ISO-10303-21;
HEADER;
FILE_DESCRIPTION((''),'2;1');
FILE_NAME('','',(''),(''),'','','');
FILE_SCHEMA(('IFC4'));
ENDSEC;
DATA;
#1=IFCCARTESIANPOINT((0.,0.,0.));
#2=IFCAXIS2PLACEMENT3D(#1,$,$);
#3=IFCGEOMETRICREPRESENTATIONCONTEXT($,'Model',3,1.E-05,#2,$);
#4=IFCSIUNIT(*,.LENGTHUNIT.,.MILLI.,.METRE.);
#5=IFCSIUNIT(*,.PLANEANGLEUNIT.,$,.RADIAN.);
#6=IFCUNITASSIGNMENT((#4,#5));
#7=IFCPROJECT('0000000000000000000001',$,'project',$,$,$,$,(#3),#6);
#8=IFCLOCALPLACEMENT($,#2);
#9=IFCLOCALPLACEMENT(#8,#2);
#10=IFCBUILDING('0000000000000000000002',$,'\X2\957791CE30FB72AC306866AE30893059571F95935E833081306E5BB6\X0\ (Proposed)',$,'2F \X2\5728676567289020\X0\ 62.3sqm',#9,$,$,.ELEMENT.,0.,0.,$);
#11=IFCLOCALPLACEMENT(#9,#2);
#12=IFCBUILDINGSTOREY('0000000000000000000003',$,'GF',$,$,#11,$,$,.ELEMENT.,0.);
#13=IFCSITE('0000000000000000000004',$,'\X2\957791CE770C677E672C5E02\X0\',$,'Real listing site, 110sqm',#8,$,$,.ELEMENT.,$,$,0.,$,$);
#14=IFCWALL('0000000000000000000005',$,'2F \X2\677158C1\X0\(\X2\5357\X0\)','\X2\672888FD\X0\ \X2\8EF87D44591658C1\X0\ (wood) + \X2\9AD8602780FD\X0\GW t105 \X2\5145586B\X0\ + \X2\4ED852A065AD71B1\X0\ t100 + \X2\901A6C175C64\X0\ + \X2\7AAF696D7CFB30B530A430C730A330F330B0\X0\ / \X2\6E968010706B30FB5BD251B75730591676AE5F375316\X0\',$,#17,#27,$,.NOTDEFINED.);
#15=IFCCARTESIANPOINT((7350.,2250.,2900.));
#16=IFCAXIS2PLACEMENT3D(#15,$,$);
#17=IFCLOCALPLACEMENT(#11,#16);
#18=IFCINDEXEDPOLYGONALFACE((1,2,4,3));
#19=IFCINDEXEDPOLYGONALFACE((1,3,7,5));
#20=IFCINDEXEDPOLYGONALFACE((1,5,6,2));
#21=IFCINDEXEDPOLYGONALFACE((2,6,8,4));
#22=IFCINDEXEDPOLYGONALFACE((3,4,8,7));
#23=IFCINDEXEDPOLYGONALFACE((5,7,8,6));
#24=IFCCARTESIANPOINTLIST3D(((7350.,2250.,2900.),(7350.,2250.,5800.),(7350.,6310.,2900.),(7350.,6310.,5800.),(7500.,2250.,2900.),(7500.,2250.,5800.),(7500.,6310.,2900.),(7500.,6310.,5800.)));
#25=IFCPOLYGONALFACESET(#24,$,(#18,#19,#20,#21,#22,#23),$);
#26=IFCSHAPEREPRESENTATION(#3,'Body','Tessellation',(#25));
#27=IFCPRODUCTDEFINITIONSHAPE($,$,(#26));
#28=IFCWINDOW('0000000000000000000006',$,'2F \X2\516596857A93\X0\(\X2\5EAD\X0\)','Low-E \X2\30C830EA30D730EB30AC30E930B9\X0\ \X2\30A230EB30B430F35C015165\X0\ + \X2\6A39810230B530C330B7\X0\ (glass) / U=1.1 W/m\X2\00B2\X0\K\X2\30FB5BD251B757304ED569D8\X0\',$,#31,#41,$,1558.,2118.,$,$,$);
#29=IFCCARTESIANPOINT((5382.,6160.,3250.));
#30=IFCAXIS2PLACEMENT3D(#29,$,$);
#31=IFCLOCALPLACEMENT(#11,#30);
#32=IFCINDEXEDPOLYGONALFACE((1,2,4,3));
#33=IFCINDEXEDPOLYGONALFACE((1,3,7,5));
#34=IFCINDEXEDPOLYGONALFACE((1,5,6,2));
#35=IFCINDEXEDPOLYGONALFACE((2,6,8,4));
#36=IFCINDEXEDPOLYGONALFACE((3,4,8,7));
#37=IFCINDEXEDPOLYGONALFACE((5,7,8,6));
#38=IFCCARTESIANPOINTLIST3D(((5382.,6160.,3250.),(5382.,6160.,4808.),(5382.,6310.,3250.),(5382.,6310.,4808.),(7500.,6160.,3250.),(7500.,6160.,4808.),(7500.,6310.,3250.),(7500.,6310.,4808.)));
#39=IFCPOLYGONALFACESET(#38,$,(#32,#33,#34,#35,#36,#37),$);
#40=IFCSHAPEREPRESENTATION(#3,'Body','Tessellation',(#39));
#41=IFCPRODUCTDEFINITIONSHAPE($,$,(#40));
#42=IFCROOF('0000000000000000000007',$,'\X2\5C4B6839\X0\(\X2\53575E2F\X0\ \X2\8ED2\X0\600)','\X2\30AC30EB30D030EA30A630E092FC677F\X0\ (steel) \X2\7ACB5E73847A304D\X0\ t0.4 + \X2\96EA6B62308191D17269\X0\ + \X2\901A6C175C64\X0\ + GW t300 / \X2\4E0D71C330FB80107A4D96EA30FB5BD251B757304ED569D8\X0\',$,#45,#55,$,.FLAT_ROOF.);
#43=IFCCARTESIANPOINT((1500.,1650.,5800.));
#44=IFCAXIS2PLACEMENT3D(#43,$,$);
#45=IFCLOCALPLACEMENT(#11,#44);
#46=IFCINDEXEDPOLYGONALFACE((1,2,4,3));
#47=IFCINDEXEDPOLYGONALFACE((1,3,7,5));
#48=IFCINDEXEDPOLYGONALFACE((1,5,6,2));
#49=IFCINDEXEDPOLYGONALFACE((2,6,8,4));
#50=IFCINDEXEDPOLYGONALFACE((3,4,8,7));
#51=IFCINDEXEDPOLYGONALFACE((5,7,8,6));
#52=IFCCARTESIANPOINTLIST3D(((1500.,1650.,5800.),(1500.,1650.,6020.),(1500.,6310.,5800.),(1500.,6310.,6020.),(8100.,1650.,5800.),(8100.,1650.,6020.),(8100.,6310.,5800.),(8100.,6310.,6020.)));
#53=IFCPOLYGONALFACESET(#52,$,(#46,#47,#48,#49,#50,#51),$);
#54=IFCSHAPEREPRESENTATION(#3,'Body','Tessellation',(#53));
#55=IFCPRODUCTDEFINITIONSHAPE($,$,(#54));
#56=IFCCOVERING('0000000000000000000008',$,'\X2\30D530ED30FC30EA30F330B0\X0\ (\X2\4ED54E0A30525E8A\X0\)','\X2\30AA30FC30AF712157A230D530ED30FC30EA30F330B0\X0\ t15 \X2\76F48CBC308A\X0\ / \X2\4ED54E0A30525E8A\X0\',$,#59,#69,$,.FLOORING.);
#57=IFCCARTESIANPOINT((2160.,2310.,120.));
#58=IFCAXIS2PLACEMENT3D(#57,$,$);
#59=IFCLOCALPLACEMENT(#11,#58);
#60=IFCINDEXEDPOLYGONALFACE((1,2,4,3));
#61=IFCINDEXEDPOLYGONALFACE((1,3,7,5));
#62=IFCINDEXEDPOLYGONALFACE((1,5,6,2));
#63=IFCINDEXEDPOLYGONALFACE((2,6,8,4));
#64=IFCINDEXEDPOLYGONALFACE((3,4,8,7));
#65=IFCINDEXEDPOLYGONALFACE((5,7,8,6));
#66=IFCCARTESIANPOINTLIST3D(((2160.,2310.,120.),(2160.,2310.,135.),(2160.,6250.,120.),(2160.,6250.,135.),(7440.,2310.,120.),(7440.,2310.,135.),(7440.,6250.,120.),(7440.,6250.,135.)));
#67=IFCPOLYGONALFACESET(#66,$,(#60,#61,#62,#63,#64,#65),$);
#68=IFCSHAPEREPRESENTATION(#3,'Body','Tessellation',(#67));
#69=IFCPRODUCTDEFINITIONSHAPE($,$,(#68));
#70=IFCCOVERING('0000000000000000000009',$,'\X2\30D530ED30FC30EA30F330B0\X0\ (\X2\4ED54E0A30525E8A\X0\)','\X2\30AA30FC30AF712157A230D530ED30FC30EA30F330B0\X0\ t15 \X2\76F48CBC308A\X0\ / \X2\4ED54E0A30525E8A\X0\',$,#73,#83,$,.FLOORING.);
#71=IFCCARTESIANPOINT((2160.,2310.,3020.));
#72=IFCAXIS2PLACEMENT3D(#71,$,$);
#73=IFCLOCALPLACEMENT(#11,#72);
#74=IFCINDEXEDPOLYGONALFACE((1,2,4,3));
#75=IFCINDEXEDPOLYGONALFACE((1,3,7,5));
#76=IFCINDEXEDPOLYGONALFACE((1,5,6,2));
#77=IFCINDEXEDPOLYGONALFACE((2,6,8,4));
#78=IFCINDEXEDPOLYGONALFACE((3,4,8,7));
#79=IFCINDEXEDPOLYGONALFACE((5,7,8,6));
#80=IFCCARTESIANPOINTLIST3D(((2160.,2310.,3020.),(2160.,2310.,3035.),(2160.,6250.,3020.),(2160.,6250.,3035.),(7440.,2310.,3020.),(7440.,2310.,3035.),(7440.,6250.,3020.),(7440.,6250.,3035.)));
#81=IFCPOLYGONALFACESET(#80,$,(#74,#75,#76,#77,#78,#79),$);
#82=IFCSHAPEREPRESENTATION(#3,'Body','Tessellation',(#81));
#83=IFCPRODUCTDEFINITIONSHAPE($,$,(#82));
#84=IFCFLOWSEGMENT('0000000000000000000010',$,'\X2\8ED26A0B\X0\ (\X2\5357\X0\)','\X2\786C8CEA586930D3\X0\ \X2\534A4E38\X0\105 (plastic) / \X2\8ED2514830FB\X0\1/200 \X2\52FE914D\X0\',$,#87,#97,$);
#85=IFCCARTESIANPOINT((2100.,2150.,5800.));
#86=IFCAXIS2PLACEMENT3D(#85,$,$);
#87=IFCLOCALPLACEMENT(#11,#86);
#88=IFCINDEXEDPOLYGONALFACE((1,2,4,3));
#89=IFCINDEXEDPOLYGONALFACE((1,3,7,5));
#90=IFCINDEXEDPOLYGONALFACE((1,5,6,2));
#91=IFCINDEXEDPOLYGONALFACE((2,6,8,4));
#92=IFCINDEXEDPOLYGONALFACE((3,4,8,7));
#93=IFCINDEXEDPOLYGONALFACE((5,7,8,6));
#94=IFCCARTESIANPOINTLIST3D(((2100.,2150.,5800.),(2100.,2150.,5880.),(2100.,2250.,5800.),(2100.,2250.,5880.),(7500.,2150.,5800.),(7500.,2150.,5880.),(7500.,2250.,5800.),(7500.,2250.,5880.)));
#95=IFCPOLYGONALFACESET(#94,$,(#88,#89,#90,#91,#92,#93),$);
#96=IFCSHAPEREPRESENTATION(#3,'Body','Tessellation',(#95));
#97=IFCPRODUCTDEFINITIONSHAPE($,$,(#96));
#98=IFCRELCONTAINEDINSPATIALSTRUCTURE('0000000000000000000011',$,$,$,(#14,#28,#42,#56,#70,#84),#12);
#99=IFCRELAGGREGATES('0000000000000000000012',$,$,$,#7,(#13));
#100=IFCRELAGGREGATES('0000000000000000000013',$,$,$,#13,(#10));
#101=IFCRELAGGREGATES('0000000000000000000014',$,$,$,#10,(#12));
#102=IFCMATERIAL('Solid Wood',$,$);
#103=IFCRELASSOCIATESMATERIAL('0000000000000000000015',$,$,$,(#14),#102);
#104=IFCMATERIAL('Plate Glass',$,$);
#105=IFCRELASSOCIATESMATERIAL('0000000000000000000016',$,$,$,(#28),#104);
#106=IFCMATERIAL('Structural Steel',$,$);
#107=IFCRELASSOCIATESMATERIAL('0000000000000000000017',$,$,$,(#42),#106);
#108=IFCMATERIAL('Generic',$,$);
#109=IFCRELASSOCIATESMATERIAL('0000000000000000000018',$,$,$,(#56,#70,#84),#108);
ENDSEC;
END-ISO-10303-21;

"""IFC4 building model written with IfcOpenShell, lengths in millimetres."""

from ifc_helpers import new_model, si_unit, frame, frame_2d, origin, place, context, project, spatial, rectangle, extrude, material, element, fill, save


model = new_model("IFC4")

# Units and contexts
model_context = context("Model", 3, precision=1e-05, world=origin())
ifc_project = project(units=[si_unit("LENGTHUNIT", "METRE", prefix="MILLI"), si_unit("PLANEANGLEUNIT", "RADIAN")], contexts=[model_context])

# Site, building, storey
site_placement = place(None, origin())
site = spatial("IfcSite", under=ifc_project, at=site_placement, Name="長野県松本市", ObjectType="Real listing site, 110sqm", CompositionType="ELEMENT", RefElevation=0.0)
building_placement = place(site_placement, origin())
building = spatial("IfcBuilding", under=site, at=building_placement, Name="長野・犬と暮らす土間広めの家 (Proposed)", ObjectType="2F 在来木造 62.3sqm", CompositionType="ELEMENT", ElevationOfRefHeight=0.0, ElevationOfTerrain=0.0)
storey_placement = place(building_placement, origin())
storey = spatial("IfcBuildingStorey", under=building, at=storey_placement, Name="GF", CompositionType="ELEMENT", Elevation=0.0)

# Shared definitions
ifc_material_1 = material(Name="Solid Wood")

# Wall, opening, window
ifc_material_2 = material(Name="Plate Glass")
wall_1_placement = place(storey_placement, frame((7350.0, 2250.0, 2900.0)))
wall_1 = element("IfcWall", 1, at=wall_1_placement, inside=storey, material=ifc_material_1, Name="2F 東壁(南)", Description="木製 軸組外壁 (wood) + 高性能GW t105 充填 + 付加断熱 t100 + 通気層 + 窯業系サイディング / 準耐火・寒冷地外皮強化", PredefinedType="NOTDEFINED", context=model_context, shape_type="SweptSolid", body=[
    extrude(rectangle(XDim=150.0, YDim=4060.0, at=frame_2d((75.0, 2030.0))), frame((7350.0, 2250.0, 2900.0)), (0.0, 0.0, 1.0), 2900.0),
])
opening_1_placement = place(storey_placement, frame((5382.0, 6160.0, 3250.0)))
opening_1 = element("IfcOpeningElement", 2, at=opening_1_placement, cuts=wall_1, PredefinedType="NOTDEFINED", context=model_context, shape_type="SweptSolid", body=[
    extrude(rectangle(XDim=2118.0, YDim=150.0, at=frame_2d((1059.0, 75.0))), frame((5382.0, 6160.0, 3250.0)), (0.0, 0.0, 1.0), 1558.0),
])
window_1_placement = place(storey_placement, frame((5382.0, 6160.0, 3250.0)))
window_1 = element("IfcWindow", 3, at=window_1_placement, inside=storey, material=ifc_material_2, Name="2F 入隅窓(庭)", Description="Low-E トリプルガラス アルゴン封入 + 樹脂サッシ (glass) / U=1.1 W/m²K・寒冷地仕様", OverallHeight=1558.0, OverallWidth=2118.0, context=model_context, shape_type="SweptSolid", body=[
    extrude(rectangle(XDim=2118.0, YDim=150.0, at=frame_2d((1059.0, 75.0))), frame((5382.0, 6160.0, 3250.0)), (0.0, 0.0, 1.0), 1558.0),
])
fill(opening_1, window_1)

# Roof
ifc_material_3 = material(Name="Structural Steel")
for number, where, name in (
    (4, (1500.0, 1650.0, 5800.0), "屋根(南帯 軒600)"),
):
    element("IfcRoof", number, at=place(storey_placement, frame(where)), inside=storey, material=ifc_material_3, Name=name, Description="ガルバリウム鋼板 (steel) 立平葺き t0.4 + 雪止め金物 + 通気層 + GW t300 / 不燃・耐積雪・寒冷地仕様", PredefinedType="FLAT_ROOF", context=model_context, shape_type="SweptSolid", body=[
        extrude(rectangle(XDim=6600.0, YDim=4660.0, at=frame_2d((3300.0, 2330.0))), frame((1500.0, 1650.0, 5800.0)), (0.0, 0.0, 1.0), 220.0),
    ])

# Coverings
ifc_material_4 = material(Name="Generic")
covering_1_placement = place(storey_placement, frame((2160.0, 2310.0, 120.0)))
element("IfcCovering", 5, at=covering_1_placement, inside=storey, material=ifc_material_4, Name="フローリング (仕上げ床)", Description="オーク無垢フローリング t15 直貼り / 仕上げ床", PredefinedType="FLOORING", context=model_context, shape_type="SweptSolid", body=[
    extrude(rectangle(XDim=5280.0, YDim=3940.0, at=frame_2d((2640.0, 1970.0))), frame((2160.0, 2310.0, 120.0)), (0.0, 0.0, 1.0), 15.0),
])
covering_2_placement = place(storey_placement, frame((2160.0, 2310.0, 3020.0)))
element("IfcCovering", 6, at=covering_2_placement, inside=storey, material=ifc_material_4, Name="フローリング (仕上げ床)", Description="オーク無垢フローリング t15 直貼り / 仕上げ床", PredefinedType="FLOORING", context=model_context, shape_type="SweptSolid", body=[
    extrude(rectangle(XDim=5280.0, YDim=3940.0, at=frame_2d((2640.0, 1970.0))), frame((2160.0, 2310.0, 3020.0)), (0.0, 0.0, 1.0), 15.0),
])

# Flow segment
flow_segment_placement = place(storey_placement, frame((2100.0, 2150.0, 5800.0)))
element("IfcFlowSegment", 7, at=flow_segment_placement, inside=storey, material=ifc_material_4, Name="軒樋 (南)", Description="硬質塩ビ 半丸105 (plastic) / 軒先・1/200 勾配", context=model_context, shape_type="SweptSolid", body=[
    extrude(rectangle(XDim=5400.0, YDim=100.0, at=frame_2d((2700.0, 50.0))), frame((2100.0, 2150.0, 5800.0)), (0.0, 0.0, 1.0), 80.0),
])

save(model, "model.ifc")
